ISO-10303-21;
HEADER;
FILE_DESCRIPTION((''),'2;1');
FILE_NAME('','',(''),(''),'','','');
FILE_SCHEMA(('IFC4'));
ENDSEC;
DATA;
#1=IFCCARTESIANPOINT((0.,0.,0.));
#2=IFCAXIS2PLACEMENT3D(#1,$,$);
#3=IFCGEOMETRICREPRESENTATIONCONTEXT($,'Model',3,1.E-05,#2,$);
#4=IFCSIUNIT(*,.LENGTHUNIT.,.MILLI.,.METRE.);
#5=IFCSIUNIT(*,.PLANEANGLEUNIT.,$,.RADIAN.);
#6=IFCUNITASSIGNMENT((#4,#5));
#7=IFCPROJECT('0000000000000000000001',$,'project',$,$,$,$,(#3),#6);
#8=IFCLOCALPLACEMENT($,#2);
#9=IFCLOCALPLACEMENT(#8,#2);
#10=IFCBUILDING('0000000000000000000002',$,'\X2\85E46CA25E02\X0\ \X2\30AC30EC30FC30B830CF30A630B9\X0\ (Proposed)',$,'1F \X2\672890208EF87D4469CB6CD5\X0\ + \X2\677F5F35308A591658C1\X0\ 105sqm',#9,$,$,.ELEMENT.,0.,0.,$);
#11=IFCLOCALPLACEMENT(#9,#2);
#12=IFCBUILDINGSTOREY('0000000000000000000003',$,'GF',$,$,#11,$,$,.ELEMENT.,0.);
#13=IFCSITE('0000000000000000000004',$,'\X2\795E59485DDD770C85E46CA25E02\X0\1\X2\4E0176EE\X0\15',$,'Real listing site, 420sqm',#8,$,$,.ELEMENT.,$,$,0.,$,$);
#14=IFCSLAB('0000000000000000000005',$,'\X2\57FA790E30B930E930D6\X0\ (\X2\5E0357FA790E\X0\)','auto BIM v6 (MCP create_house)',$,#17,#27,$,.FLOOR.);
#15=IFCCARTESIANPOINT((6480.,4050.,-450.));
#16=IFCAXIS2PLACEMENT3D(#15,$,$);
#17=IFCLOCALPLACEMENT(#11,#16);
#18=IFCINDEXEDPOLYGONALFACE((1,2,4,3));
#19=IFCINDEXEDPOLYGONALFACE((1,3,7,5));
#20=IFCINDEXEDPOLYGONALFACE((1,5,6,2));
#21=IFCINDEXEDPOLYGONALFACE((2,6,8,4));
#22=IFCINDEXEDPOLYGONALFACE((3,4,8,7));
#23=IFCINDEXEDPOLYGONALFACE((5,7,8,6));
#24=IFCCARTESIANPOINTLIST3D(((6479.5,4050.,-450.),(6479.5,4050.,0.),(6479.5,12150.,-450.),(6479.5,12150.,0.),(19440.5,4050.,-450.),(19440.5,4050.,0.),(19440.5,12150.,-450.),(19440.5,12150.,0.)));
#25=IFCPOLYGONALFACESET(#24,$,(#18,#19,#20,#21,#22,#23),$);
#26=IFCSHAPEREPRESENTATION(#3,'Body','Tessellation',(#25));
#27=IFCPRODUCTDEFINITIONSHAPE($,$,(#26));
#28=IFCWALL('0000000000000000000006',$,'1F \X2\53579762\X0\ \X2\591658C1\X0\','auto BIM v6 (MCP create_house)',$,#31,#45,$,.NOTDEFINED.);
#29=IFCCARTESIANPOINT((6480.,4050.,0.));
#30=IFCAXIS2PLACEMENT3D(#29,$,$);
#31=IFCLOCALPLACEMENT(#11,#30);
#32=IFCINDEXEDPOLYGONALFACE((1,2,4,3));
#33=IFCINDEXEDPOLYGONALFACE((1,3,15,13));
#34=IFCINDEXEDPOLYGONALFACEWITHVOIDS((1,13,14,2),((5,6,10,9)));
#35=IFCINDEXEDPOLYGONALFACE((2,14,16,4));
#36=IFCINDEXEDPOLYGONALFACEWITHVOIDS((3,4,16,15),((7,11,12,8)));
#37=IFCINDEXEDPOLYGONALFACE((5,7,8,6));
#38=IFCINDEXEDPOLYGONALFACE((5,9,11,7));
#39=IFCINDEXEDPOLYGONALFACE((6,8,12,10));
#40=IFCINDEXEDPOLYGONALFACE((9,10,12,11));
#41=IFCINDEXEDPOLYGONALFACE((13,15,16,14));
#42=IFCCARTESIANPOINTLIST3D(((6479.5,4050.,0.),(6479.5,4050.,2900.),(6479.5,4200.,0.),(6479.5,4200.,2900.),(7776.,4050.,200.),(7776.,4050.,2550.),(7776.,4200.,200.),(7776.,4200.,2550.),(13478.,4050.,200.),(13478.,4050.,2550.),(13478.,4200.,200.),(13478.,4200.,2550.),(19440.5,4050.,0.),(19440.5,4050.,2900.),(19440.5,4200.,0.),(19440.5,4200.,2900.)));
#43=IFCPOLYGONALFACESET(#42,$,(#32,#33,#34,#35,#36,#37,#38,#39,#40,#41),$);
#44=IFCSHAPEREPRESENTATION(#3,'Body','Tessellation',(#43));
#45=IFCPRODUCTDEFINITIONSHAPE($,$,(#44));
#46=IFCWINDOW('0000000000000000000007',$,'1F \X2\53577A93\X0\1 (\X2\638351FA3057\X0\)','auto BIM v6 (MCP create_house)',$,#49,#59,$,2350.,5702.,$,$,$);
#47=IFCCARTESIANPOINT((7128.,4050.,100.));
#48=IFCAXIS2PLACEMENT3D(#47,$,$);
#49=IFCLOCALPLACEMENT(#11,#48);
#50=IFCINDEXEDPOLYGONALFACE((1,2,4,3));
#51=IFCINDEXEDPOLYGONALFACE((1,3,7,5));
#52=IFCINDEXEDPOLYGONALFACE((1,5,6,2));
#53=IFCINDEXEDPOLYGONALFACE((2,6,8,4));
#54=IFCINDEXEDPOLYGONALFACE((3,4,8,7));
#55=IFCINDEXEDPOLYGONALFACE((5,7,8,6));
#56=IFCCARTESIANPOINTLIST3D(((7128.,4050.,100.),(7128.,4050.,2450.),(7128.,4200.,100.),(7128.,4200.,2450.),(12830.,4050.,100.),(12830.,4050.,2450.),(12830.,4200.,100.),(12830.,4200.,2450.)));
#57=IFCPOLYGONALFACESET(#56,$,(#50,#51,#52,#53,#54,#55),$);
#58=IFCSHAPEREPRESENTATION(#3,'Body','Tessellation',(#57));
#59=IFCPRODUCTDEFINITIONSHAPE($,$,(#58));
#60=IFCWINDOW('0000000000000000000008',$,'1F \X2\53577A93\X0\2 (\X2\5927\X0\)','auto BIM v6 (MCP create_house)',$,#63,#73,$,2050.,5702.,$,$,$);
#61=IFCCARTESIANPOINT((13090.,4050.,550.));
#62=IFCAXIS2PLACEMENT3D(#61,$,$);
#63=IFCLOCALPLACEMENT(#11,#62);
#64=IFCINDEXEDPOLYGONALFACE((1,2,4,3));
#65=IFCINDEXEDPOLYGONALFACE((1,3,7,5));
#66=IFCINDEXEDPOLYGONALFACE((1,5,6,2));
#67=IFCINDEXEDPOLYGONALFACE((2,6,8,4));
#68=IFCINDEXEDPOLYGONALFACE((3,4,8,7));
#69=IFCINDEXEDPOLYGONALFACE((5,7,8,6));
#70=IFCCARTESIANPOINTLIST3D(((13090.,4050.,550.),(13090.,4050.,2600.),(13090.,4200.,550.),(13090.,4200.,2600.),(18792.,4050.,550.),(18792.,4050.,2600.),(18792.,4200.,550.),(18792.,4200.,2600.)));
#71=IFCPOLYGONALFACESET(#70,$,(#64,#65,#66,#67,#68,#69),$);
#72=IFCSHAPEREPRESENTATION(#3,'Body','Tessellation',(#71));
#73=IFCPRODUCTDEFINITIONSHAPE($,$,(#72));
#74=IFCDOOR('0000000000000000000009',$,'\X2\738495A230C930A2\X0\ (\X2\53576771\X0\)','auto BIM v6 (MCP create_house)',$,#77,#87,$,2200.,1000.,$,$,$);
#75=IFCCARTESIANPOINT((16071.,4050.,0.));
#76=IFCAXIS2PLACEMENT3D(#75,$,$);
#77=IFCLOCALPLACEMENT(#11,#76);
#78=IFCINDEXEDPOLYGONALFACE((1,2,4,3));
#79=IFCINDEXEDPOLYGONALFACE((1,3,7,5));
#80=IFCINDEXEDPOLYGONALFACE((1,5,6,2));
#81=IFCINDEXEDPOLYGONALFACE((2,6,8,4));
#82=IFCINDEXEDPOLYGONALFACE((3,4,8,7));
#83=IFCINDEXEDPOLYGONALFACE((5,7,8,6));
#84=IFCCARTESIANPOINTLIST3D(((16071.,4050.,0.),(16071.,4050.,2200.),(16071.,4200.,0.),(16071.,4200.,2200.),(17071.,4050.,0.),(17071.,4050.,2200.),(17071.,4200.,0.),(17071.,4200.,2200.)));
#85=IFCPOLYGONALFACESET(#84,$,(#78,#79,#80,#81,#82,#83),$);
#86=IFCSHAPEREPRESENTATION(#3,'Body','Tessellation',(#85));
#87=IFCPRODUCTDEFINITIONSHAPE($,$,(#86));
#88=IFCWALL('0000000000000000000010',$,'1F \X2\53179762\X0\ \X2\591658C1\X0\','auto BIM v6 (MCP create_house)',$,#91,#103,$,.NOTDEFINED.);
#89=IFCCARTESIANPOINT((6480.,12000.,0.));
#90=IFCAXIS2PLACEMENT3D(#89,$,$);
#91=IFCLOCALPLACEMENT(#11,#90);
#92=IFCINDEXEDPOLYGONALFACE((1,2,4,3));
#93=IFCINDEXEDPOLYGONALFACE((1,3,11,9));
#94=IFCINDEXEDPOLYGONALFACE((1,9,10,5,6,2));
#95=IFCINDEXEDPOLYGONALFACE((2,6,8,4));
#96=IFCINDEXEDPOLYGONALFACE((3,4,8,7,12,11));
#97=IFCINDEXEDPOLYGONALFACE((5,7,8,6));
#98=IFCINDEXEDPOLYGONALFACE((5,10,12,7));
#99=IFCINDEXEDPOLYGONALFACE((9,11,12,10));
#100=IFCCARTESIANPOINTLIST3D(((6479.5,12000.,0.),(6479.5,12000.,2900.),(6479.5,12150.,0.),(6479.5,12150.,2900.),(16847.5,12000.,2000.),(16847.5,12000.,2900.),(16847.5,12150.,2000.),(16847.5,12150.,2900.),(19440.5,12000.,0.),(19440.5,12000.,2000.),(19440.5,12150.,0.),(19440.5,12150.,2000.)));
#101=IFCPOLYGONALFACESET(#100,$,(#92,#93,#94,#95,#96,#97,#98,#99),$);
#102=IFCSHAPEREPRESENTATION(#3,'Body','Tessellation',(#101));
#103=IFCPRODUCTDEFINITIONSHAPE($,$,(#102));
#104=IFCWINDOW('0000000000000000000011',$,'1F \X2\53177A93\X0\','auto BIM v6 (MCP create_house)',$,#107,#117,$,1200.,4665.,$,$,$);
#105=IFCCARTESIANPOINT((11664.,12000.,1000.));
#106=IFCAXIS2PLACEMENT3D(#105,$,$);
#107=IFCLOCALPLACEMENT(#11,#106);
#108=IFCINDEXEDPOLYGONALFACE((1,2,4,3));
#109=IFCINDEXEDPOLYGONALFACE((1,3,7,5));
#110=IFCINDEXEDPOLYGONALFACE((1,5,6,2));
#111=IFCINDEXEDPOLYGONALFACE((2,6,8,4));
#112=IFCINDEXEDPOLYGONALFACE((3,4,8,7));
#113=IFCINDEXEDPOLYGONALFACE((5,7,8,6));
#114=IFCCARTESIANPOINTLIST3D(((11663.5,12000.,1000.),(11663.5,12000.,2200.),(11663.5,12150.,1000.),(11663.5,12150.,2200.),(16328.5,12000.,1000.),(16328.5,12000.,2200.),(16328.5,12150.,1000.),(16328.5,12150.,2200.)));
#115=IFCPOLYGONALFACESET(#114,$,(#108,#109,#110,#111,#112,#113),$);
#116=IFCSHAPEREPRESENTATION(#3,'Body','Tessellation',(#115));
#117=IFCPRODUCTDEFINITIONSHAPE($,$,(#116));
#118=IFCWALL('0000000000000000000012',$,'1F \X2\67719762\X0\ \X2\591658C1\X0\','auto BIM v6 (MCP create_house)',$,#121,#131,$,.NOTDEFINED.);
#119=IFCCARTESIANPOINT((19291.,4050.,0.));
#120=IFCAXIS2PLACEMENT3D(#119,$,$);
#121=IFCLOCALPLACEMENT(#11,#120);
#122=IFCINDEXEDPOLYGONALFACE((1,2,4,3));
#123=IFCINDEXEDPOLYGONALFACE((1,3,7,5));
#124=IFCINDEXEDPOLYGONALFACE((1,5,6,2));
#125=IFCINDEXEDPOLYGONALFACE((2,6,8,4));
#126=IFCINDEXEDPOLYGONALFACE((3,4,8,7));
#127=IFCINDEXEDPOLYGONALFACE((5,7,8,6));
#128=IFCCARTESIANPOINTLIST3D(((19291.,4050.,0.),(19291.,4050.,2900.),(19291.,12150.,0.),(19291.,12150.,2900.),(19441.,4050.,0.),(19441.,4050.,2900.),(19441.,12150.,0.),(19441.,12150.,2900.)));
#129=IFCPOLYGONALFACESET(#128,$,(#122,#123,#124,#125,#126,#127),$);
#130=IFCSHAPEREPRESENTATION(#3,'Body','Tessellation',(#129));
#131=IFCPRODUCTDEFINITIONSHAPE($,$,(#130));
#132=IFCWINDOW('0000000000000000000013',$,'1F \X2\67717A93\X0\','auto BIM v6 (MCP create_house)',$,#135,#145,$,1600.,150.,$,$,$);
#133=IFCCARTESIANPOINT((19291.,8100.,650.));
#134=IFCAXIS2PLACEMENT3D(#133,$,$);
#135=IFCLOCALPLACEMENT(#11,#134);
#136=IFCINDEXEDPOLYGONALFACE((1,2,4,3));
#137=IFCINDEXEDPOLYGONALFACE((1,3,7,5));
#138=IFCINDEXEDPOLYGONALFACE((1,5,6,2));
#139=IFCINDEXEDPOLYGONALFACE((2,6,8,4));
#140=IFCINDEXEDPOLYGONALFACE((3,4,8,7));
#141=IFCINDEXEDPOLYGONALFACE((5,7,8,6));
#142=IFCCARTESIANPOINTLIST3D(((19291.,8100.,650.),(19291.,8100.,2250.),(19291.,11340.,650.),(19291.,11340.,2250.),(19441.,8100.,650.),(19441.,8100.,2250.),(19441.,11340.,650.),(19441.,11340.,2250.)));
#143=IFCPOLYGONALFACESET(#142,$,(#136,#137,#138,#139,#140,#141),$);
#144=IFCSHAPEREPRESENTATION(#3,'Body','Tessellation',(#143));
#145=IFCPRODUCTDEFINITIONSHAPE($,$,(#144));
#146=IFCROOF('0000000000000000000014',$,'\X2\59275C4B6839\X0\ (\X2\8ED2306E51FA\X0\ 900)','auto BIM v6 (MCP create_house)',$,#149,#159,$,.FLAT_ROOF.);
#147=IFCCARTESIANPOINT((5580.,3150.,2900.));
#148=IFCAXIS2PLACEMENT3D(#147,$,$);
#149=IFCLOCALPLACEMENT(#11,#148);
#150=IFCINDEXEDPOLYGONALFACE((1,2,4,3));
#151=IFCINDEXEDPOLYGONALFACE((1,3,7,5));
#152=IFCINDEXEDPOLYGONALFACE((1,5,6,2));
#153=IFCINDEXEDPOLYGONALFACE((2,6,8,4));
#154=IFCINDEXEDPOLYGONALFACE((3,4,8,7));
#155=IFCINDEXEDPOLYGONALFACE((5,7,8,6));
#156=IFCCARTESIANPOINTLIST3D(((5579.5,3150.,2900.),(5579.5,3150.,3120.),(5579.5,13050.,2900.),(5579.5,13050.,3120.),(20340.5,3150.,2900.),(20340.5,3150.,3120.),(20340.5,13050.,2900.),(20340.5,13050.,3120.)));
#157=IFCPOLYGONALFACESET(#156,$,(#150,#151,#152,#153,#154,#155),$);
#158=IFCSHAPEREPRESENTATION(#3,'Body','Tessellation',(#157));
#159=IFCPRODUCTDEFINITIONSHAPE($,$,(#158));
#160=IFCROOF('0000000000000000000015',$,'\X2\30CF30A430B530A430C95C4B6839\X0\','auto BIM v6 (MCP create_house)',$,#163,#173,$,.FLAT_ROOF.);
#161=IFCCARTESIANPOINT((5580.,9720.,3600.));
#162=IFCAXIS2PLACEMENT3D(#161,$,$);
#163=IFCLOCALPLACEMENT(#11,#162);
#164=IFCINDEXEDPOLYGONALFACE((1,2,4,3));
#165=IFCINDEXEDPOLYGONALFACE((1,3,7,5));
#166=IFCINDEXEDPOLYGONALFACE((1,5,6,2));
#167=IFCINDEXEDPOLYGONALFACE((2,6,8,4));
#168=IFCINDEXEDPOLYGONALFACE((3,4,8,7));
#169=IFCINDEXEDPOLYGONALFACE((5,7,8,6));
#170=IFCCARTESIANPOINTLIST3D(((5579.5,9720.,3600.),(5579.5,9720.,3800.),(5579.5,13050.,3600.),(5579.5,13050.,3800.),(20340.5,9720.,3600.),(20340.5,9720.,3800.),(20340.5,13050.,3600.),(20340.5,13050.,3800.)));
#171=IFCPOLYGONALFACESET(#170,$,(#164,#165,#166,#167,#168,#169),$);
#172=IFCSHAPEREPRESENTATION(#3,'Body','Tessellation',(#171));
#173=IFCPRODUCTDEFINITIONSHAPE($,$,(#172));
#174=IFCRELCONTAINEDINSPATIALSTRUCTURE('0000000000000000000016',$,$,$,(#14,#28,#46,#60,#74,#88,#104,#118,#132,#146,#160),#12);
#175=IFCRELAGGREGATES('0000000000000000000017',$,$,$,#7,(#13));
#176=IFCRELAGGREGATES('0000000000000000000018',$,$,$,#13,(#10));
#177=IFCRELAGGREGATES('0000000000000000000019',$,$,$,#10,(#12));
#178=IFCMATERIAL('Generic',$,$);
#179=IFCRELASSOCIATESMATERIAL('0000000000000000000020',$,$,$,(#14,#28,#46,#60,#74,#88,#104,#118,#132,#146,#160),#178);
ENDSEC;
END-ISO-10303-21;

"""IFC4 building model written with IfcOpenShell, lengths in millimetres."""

from ifc_helpers import new_model, si_unit, frame, frame_2d, origin, place, context, project, spatial, rectangle, extrude, material, element, fill, save


model = new_model("IFC4")

# Units and contexts
model_context = context("Model", 3, precision=1e-05, world=origin())
ifc_project = project(units=[si_unit("LENGTHUNIT", "METRE", prefix="MILLI"), si_unit("PLANEANGLEUNIT", "RADIAN")], contexts=[model_context])

# Site, building, storey
site_placement = place(None, origin())
site = spatial("IfcSite", under=ifc_project, at=site_placement, Name="神奈川県藤沢市1丁目15", ObjectType="Real listing site, 420sqm", CompositionType="ELEMENT", RefElevation=0.0)
building_placement = place(site_placement, origin())
building = spatial("IfcBuilding", under=site, at=building_placement, Name="藤沢市 ガレージハウス (Proposed)", ObjectType="1F 木造軸組構法 + 板張り外壁 105sqm", CompositionType="ELEMENT", ElevationOfRefHeight=0.0, ElevationOfTerrain=0.0)
storey_placement = place(building_placement, origin())
storey = spatial("IfcBuildingStorey", under=building, at=storey_placement, Name="GF", CompositionType="ELEMENT", Elevation=0.0)

# Slab
ifc_material = material(Name="Generic")
slab_1_placement = place(storey_placement, frame((6480.0, 4050.0, -450.0)))
element("IfcSlab", 1, at=slab_1_placement, inside=storey, material=ifc_material, Name="基礎スラブ (布基礎)", Description="auto BIM v6 (MCP create_house)", PredefinedType="FLOOR", context=model_context, shape_type="SweptSolid", body=[
    extrude(rectangle(XDim=12961.0, YDim=8100.0, at=frame_2d((6480.0, 4050.0))), frame((6480.0, 4050.0, -450.0)), (0.0, 0.0, 1.0), 450.0),
])

# Wall, openings, windows, door
wall_1_placement = place(storey_placement, frame((6480.0, 4050.0, 0.0)))
wall_1 = element("IfcWall", 2, at=wall_1_placement, inside=storey, material=ifc_material, Name="1F 南面 外壁", Description="auto BIM v6 (MCP create_house)", PredefinedType="NOTDEFINED", context=model_context, shape_type="SweptSolid", body=[
    extrude(rectangle(XDim=12961.0, YDim=150.0, at=frame_2d((6480.0, 75.0))), frame((6480.0, 4050.0, 0.0)), (0.0, 0.0, 1.0), 2900.0),
])
opening_1_placement = place(storey_placement, frame((7128.0, 4050.0, 100.0)))
opening_1 = element("IfcOpeningElement", 3, at=opening_1_placement, cuts=wall_1, PredefinedType="NOTDEFINED", context=model_context, shape_type="SweptSolid", body=[
    extrude(rectangle(XDim=5702.0, YDim=150.0, at=frame_2d((2851.0, 75.0))), frame((7128.0, 4050.0, 100.0)), (0.0, 0.0, 1.0), 2350.0),
])
opening_2_placement = place(storey_placement, frame((13090.0, 4050.0, 550.0)))
opening_2 = element("IfcOpeningElement", 4, at=opening_2_placement, cuts=wall_1, PredefinedType="NOTDEFINED", context=model_context, shape_type="SweptSolid", body=[
    extrude(rectangle(XDim=5702.0, YDim=150.0, at=frame_2d((2851.0, 75.0))), frame((13090.0, 4050.0, 550.0)), (0.0, 0.0, 1.0), 2050.0),
])
opening_3_placement = place(storey_placement, frame((16071.0, 4050.0, 0.0)))
opening_3 = element("IfcOpeningElement", 5, at=opening_3_placement, cuts=wall_1, PredefinedType="NOTDEFINED", context=model_context, shape_type="SweptSolid", body=[
    extrude(rectangle(XDim=1000.0, YDim=150.0, at=frame_2d((500.0, 75.0))), frame((16071.0, 4050.0, 0.0)), (0.0, 0.0, 1.0), 2200.0),
])
window_1_placement = place(storey_placement, frame((7128.0, 4050.0, 100.0)))
window_1 = element("IfcWindow", 6, at=window_1_placement, inside=storey, material=ifc_material, Name="1F 南窓1 (掃出し)", Description="auto BIM v6 (MCP create_house)", OverallHeight=2350.0, OverallWidth=5702.0, context=model_context, shape_type="SweptSolid", body=[
    extrude(rectangle(XDim=5702.0, YDim=150.0, at=frame_2d((2851.0, 75.0))), frame((7128.0, 4050.0, 100.0)), (0.0, 0.0, 1.0), 2350.0),
])
fill(opening_1, window_1)
window_2_placement = place(storey_placement, frame((13090.0, 4050.0, 550.0)))
window_2 = element("IfcWindow", 7, at=window_2_placement, inside=storey, material=ifc_material, Name="1F 南窓2 (大)", Description="auto BIM v6 (MCP create_house)", OverallHeight=2050.0, OverallWidth=5702.0, context=model_context, shape_type="SweptSolid", body=[
    extrude(rectangle(XDim=5702.0, YDim=150.0, at=frame_2d((2851.0, 75.0))), frame((13090.0, 4050.0, 550.0)), (0.0, 0.0, 1.0), 2050.0),
])
fill(opening_2, window_2)
door_placement = place(storey_placement, frame((16071.0, 4050.0, 0.0)))
door = element("IfcDoor", 8, at=door_placement, inside=storey, material=ifc_material, Name="玄関ドア (南東)", Description="auto BIM v6 (MCP create_house)", OverallHeight=2200.0, OverallWidth=1000.0, context=model_context, shape_type="SweptSolid", body=[
    extrude(rectangle(XDim=1000.0, YDim=150.0, at=frame_2d((500.0, 75.0))), frame((16071.0, 4050.0, 0.0)), (0.0, 0.0, 1.0), 2200.0),
])
fill(opening_3, door)

# Walls, openings, windows
wall_2_placement = place(storey_placement, frame((6480.0, 12000.0, 0.0)))
wall_2 = element("IfcWall", 9, at=wall_2_placement, inside=storey, material=ifc_material, Name="1F 北面 外壁", Description="auto BIM v6 (MCP create_house)", PredefinedType="NOTDEFINED", context=model_context, shape_type="SweptSolid", body=[
    extrude(rectangle(XDim=12961.0, YDim=150.0, at=frame_2d((6480.0, 75.0))), frame((6480.0, 12000.0, 0.0)), (0.0, 0.0, 1.0), 2900.0),
])
opening_4_placement = place(storey_placement, frame((11664.0, 12000.0, 1000.0)))
opening_4 = element("IfcOpeningElement", 10, at=opening_4_placement, cuts=wall_2, PredefinedType="NOTDEFINED", context=model_context, shape_type="SweptSolid", body=[
    extrude(rectangle(XDim=4665.0, YDim=150.0, at=frame_2d((2332.0, 75.0))), frame((11664.0, 12000.0, 1000.0)), (0.0, 0.0, 1.0), 1200.0),
])
window_3_placement = place(storey_placement, frame((11664.0, 12000.0, 1000.0)))
window_3 = element("IfcWindow", 11, at=window_3_placement, inside=storey, material=ifc_material, Name="1F 北窓", Description="auto BIM v6 (MCP create_house)", OverallHeight=1200.0, OverallWidth=4665.0, context=model_context, shape_type="SweptSolid", body=[
    extrude(rectangle(XDim=4665.0, YDim=150.0, at=frame_2d((2332.0, 75.0))), frame((11664.0, 12000.0, 1000.0)), (0.0, 0.0, 1.0), 1200.0),
])
fill(opening_4, window_3)
wall_3_placement = place(storey_placement, frame((19291.0, 4050.0, 0.0)))
wall_3 = element("IfcWall", 12, at=wall_3_placement, inside=storey, material=ifc_material, Name="1F 東面 外壁", Description="auto BIM v6 (MCP create_house)", PredefinedType="NOTDEFINED", context=model_context, shape_type="SweptSolid", body=[
    extrude(rectangle(XDim=150.0, YDim=8100.0, at=frame_2d((75.0, 4050.0))), frame((19291.0, 4050.0, 0.0)), (0.0, 0.0, 1.0), 2900.0),
])
opening_5_placement = place(storey_placement, frame((19291.0, 8100.0, 650.0)))
opening_5 = element("IfcOpeningElement", 13, at=opening_5_placement, cuts=wall_3, PredefinedType="NOTDEFINED", context=model_context, shape_type="SweptSolid", body=[
    extrude(rectangle(XDim=150.0, YDim=3240.0, at=frame_2d((75.0, 1620.0))), frame((19291.0, 8100.0, 650.0)), (0.0, 0.0, 1.0), 1600.0),
])
window_4_placement = place(storey_placement, frame((19291.0, 8100.0, 650.0)))
window_4 = element("IfcWindow", 14, at=window_4_placement, inside=storey, material=ifc_material, Name="1F 東窓", Description="auto BIM v6 (MCP create_house)", OverallHeight=1600.0, OverallWidth=150.0, context=model_context, shape_type="SweptSolid", body=[
    extrude(rectangle(XDim=150.0, YDim=3240.0, at=frame_2d((75.0, 1620.0))), frame((19291.0, 8100.0, 650.0)), (0.0, 0.0, 1.0), 1600.0),
])
fill(opening_5, window_4)

# Roofs
roof_1_placement = place(storey_placement, frame((5580.0, 3150.0, 2900.0)))
element("IfcRoof", 15, at=roof_1_placement, inside=storey, material=ifc_material, Name="大屋根 (軒の出 900)", Description="auto BIM v6 (MCP create_house)", PredefinedType="FLAT_ROOF", context=model_context, shape_type="SweptSolid", body=[
    extrude(rectangle(XDim=14761.0, YDim=9900.0, at=frame_2d((7380.0, 4950.0))), frame((5580.0, 3150.0, 2900.0)), (0.0, 0.0, 1.0), 220.0),
])
roof_2_placement = place(storey_placement, frame((5580.0, 9720.0, 3600.0)))
element("IfcRoof", 16, at=roof_2_placement, inside=storey, material=ifc_material, Name="ハイサイド屋根", Description="auto BIM v6 (MCP create_house)", PredefinedType="FLAT_ROOF", context=model_context, shape_type="SweptSolid", body=[
    extrude(rectangle(XDim=14761.0, YDim=3330.0, at=frame_2d((7380.0, 1665.0))), frame((5580.0, 9720.0, 3600.0)), (0.0, 0.0, 1.0), 200.0),
])

save(model, "model.ifc")
